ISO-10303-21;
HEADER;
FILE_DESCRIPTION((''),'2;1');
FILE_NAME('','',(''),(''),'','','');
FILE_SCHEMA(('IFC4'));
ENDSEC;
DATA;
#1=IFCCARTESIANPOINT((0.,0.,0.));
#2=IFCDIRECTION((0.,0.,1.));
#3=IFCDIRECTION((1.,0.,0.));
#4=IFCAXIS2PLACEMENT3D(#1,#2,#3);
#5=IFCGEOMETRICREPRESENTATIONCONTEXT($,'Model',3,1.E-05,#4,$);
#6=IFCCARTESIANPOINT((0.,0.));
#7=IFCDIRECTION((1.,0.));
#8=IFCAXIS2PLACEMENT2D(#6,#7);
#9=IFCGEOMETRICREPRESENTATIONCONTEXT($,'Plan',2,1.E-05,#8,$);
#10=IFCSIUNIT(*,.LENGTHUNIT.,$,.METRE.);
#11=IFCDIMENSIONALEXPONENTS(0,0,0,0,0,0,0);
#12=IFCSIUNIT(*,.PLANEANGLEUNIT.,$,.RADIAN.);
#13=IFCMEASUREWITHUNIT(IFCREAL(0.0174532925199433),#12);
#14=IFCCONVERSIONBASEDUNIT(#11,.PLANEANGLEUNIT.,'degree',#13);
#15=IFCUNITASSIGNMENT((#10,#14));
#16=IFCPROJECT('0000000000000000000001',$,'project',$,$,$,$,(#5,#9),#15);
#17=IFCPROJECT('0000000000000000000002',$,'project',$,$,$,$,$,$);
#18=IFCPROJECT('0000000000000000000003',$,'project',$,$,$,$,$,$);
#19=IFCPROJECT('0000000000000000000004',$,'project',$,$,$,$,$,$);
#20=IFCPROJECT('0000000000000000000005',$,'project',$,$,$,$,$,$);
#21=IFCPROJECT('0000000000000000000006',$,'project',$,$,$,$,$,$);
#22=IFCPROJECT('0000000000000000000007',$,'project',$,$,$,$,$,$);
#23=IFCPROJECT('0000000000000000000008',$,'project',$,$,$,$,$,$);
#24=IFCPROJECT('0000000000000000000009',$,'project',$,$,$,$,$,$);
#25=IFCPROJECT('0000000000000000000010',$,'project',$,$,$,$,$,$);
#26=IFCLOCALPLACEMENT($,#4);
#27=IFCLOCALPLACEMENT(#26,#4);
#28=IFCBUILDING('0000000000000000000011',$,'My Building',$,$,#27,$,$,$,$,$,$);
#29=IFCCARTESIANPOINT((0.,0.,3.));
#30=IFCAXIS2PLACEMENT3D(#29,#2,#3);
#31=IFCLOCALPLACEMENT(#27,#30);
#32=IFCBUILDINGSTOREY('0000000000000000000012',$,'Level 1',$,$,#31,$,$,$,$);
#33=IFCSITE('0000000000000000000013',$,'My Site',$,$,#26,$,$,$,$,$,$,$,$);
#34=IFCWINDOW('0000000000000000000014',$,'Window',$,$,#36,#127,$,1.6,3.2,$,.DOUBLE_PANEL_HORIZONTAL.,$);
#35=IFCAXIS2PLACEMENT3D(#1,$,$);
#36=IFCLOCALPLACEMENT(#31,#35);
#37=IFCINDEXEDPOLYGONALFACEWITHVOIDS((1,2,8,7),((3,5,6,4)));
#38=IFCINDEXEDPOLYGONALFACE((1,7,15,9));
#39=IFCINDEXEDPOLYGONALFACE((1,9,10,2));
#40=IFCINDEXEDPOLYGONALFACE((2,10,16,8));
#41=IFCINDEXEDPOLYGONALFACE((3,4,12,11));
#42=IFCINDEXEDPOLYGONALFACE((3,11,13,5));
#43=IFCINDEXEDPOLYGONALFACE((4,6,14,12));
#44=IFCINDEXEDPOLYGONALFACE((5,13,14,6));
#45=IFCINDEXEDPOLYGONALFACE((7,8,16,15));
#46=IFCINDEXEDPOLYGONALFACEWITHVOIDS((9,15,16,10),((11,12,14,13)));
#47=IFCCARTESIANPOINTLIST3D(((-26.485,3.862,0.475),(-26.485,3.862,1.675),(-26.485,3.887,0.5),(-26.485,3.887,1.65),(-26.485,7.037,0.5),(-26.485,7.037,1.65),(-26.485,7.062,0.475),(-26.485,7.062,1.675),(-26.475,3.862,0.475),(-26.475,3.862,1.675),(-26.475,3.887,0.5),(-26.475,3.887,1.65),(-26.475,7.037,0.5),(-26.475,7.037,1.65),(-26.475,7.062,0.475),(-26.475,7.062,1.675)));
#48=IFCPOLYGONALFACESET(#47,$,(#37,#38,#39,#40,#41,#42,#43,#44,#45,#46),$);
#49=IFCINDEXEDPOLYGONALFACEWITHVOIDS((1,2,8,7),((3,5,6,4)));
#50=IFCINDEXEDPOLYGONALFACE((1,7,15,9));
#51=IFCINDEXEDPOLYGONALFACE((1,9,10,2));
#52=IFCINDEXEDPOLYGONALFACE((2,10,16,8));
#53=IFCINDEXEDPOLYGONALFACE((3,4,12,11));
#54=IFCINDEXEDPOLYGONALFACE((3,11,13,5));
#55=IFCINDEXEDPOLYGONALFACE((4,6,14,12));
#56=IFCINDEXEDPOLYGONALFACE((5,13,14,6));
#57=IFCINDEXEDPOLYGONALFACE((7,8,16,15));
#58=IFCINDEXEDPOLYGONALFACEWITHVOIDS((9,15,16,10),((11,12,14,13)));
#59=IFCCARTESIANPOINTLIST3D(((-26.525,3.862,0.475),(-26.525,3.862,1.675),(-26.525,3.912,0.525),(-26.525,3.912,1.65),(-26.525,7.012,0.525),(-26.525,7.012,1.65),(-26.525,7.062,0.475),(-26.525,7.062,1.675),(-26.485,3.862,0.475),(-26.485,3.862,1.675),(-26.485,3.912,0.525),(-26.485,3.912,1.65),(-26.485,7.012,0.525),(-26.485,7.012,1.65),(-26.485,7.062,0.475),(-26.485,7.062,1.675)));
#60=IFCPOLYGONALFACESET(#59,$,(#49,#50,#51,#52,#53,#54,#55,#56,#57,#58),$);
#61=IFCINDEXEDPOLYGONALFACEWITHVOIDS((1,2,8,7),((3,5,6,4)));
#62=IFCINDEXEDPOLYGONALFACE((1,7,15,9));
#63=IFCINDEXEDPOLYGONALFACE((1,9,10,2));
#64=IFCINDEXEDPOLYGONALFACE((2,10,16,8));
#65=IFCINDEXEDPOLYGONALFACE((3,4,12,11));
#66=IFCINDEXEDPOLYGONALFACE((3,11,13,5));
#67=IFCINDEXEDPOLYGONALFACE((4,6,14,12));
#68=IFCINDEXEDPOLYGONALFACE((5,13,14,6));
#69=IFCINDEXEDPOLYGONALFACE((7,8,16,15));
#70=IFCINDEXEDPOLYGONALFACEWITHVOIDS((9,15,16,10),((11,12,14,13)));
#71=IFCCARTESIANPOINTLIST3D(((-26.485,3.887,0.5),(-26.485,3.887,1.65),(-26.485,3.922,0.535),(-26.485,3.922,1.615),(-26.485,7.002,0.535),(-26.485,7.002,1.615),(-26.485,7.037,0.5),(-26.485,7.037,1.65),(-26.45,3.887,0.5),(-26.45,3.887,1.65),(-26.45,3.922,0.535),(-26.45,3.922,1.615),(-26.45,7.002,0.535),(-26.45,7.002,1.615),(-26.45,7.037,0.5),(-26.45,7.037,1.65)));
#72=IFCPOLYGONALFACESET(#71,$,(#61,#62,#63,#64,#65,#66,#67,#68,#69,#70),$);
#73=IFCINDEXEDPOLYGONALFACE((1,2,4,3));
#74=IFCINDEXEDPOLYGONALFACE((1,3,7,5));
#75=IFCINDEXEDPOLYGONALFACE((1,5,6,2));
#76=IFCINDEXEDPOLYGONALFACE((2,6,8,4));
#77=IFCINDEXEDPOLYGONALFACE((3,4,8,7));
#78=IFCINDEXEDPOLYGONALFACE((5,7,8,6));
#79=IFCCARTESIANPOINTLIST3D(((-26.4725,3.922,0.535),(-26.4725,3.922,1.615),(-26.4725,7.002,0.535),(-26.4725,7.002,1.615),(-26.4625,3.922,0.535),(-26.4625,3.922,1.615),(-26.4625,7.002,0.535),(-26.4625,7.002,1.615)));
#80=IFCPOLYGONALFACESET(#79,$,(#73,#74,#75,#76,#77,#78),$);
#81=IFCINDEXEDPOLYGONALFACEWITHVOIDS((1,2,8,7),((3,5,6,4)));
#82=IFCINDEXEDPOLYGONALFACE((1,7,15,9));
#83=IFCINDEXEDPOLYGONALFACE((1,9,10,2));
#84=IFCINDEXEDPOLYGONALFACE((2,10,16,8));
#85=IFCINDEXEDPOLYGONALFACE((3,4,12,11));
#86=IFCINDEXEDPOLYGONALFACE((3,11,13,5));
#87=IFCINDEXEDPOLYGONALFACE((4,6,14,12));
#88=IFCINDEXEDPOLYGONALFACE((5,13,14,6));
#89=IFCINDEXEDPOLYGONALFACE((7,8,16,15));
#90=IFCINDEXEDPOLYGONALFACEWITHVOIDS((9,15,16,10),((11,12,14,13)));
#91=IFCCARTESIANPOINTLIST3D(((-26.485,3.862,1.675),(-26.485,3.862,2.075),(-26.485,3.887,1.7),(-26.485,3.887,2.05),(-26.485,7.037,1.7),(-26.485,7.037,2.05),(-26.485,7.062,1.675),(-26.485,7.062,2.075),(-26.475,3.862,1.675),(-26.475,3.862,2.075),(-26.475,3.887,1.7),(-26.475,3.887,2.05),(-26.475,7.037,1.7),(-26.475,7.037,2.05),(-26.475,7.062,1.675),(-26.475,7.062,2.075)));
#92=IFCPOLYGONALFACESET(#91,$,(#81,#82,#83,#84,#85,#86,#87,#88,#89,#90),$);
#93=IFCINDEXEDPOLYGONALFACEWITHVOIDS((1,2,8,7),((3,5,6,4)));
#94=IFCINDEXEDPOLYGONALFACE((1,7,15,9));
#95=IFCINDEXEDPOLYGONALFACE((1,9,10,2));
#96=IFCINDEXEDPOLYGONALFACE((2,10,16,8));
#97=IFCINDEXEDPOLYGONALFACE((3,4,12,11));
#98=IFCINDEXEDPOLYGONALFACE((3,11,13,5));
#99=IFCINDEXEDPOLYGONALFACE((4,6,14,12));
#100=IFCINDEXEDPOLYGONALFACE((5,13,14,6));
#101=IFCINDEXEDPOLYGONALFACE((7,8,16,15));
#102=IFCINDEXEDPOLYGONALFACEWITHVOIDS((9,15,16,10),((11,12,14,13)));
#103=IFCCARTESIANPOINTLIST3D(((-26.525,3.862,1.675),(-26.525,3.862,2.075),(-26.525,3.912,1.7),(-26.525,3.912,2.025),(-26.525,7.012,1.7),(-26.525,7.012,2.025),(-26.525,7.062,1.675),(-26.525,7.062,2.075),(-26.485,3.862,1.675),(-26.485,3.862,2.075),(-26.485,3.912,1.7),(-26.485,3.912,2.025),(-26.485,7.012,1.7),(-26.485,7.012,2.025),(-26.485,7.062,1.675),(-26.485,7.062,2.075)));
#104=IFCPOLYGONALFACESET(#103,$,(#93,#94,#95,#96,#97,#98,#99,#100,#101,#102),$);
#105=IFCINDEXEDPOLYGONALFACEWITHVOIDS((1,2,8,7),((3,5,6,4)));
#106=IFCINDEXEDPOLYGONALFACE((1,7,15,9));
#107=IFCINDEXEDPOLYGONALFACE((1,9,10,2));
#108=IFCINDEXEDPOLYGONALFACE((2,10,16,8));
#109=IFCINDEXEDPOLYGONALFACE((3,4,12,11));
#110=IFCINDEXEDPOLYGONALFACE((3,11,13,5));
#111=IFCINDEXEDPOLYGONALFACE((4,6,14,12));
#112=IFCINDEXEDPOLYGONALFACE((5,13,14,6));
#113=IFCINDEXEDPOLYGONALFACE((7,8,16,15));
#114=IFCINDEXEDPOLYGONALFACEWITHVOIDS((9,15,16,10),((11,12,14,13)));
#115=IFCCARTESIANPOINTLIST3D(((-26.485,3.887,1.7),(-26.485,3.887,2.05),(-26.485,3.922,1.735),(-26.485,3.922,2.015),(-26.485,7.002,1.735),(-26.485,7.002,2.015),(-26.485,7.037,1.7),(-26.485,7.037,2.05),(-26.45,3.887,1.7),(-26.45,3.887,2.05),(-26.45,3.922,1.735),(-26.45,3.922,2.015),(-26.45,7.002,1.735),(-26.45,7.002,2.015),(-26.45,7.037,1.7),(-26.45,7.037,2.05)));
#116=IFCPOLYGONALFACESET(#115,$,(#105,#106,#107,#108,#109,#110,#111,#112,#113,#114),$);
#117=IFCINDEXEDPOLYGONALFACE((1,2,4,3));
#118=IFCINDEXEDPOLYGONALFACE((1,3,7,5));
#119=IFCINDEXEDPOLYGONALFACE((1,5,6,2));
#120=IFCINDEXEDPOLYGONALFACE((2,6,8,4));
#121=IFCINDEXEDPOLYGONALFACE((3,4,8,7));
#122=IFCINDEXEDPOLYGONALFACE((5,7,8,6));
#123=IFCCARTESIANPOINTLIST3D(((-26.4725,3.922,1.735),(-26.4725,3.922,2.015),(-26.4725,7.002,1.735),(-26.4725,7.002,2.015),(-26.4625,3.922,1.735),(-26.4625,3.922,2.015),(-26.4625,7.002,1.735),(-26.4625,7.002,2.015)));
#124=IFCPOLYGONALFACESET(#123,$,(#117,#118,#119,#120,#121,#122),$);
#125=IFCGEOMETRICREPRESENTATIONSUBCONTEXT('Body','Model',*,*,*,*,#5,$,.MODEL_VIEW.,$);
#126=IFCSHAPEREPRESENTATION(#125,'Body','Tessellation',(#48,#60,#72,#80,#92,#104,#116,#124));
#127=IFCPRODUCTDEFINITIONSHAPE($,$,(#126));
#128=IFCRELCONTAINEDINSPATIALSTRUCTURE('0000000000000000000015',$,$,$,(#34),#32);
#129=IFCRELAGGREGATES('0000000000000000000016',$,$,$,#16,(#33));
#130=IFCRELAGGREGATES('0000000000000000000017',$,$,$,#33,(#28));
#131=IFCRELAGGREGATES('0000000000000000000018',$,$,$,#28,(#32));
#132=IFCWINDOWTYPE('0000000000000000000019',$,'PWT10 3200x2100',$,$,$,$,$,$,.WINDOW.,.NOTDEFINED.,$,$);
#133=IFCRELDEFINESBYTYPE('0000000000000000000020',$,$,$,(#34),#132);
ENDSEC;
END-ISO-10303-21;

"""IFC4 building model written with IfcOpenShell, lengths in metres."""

from ifc_helpers import new_model, entity, si_unit, converted_unit, frame, origin_with_axes, origin_2d_with_axis, place, context, subcontext, project, spatial, line, indexed_curve, outline, extrude, shape, source, transform, mapped, type_object, type_shapes, element, save


model = new_model("IFC4")

# Units and contexts
model_context = context("Model", 3, precision=1e-05, world=origin_with_axes())
plan_context = context("Plan", 2, precision=1e-05, world=origin_2d_with_axis())
body_context_1 = subcontext(model_context, "Body", "Model", "MODEL_VIEW")
body_context_2 = subcontext(plan_context, "Body", "Plan", "PLAN_VIEW")
ifc_project_1 = project(units=[si_unit("LENGTHUNIT", "METRE"), converted_unit("PLANEANGLEUNIT", "degree", entity("IfcReal", 0.0174532925199433), si_unit("PLANEANGLEUNIT", "RADIAN"), dimensions=[0, 0, 0, 0, 0, 0, 0])], contexts=[model_context, plan_context])
ifc_project_2 = project()
ifc_project_3 = project()
ifc_project_4 = project()
ifc_project_5 = project()
ifc_project_6 = project()
ifc_project_7 = project()
ifc_project_8 = project()
ifc_project_9 = project()
ifc_project_10 = project()

# Site, building, storey
site_placement = place(None, origin_with_axes())
site = spatial("IfcSite", under=ifc_project_1, at=site_placement, Name="My Site")
building_placement = place(site_placement, origin_with_axes())
building = spatial("IfcBuilding", under=site, at=building_placement, Name="My Building")
storey_placement = place(building_placement, frame((0.0, 0.0, 3.0), z_axis=(0.0, 0.0, 1.0), x_axis=(1.0, 0.0, 0.0)))
storey = spatial("IfcBuildingStorey", under=building, at=storey_placement, Name="Level 1")

# Window
window_type_1 = type_object("IfcWindowType", Name="PWT10 3200x2100", PartitioningType="NOTDEFINED", PredefinedType="WINDOW")
shared_shape_1 = source(origin_with_axes(), body_context_1, "Body", "SweptSolid", [
    extrude(outline(indexed_curve([(0.0, 0.0), (3.2, 0.0), (3.2, 1.2), (0.0, 1.2)], segments=[line(1, 2, 2, 3, 3, 4, 4, 1)]), holes=[indexed_curve([(0.025, 0.025), (3.175, 0.025), (3.175, 1.175), (0.025, 1.175)], segments=[line(1, 2, 2, 3, 3, 4, 4, 1)])]), frame((0.0, 0.04, 0.0), z_axis=(0.0, -1.0, 0.0), x_axis=(1.0, 0.0, 0.0)), (0.0, 0.0, -1.0), 0.01),
    extrude(outline(indexed_curve([(0.0, 0.0), (3.2, 0.0), (3.2, 1.2), (0.0, 1.2)], segments=[line(1, 2, 2, 3, 3, 4, 4, 1)]), holes=[indexed_curve([(0.05, 0.05), (3.15, 0.05), (3.15, 1.175), (0.05, 1.175)], segments=[line(1, 2, 2, 3, 3, 4, 4, 1)])]), frame((0.0, 0.0, 0.0), z_axis=(0.0, -1.0, 0.0), x_axis=(1.0, 0.0, 0.0)), (0.0, 0.0, -1.0), 0.04),
    extrude(outline(indexed_curve([(0.0, 0.0), (3.15, 0.0), (3.15, 1.15), (0.0, 1.15)], segments=[line(1, 2, 2, 3, 3, 4, 4, 1)]), holes=[indexed_curve([(0.035, 0.035), (3.115, 0.035), (3.115, 1.115), (0.035, 1.115)], segments=[line(1, 2, 2, 3, 3, 4, 4, 1)])]), frame((0.025, 0.04, 0.025), z_axis=(0.0, -1.0, 0.0), x_axis=(1.0, 0.0, 0.0)), (0.0, 0.0, -1.0), 0.035),
    extrude(outline(indexed_curve([(0.035, 0.035), (3.115, 0.035), (3.115, 1.115), (0.035, 1.115)], segments=[line(1, 2, 2, 3, 3, 4, 4, 1)])), frame((0.025, 0.0525, 0.025), z_axis=(0.0, -1.0, 0.0), x_axis=(1.0, 0.0, 0.0)), (0.0, 0.0, -1.0), 0.01),
    extrude(outline(indexed_curve([(0.0, 0.0), (3.2, 0.0), (3.2, 0.4), (0.0, 0.4)], segments=[line(1, 2, 2, 3, 3, 4, 4, 1)]), holes=[indexed_curve([(0.025, 0.025), (3.175, 0.025), (3.175, 0.375), (0.025, 0.375)], segments=[line(1, 2, 2, 3, 3, 4, 4, 1)])]), frame((0.0, 0.04, 1.2), z_axis=(0.0, -1.0, 0.0), x_axis=(1.0, 0.0, 0.0)), (0.0, 0.0, -1.0), 0.01),
    extrude(outline(indexed_curve([(0.0, 0.0), (3.2, 0.0), (3.2, 0.4), (0.0, 0.4)], segments=[line(1, 2, 2, 3, 3, 4, 4, 1)]), holes=[indexed_curve([(0.05, 0.025), (3.15, 0.025), (3.15, 0.35), (0.05, 0.35)], segments=[line(1, 2, 2, 3, 3, 4, 4, 1)])]), frame((0.0, 0.0, 1.2), z_axis=(0.0, -1.0, 0.0), x_axis=(1.0, 0.0, 0.0)), (0.0, 0.0, -1.0), 0.04),
    extrude(outline(indexed_curve([(0.0, 0.0), (3.15, 0.0), (3.15, 0.35), (0.0, 0.35)], segments=[line(1, 2, 2, 3, 3, 4, 4, 1)]), holes=[indexed_curve([(0.035, 0.035), (3.115, 0.035), (3.115, 0.315), (0.035, 0.315)], segments=[line(1, 2, 2, 3, 3, 4, 4, 1)])]), frame((0.025, 0.04, 1.225), z_axis=(0.0, -1.0, 0.0), x_axis=(1.0, 0.0, 0.0)), (0.0, 0.0, -1.0), 0.035),
    extrude(outline(indexed_curve([(0.035, 0.035), (3.115, 0.035), (3.115, 0.315), (0.035, 0.315)], segments=[line(1, 2, 2, 3, 3, 4, 4, 1)])), frame((0.025, 0.0525, 1.225), z_axis=(0.0, -1.0, 0.0), x_axis=(1.0, 0.0, 0.0)), (0.0, 0.0, -1.0), 0.01),
])
shared_shape_2 = source(origin_with_axes(), body_context_2, "Body", "Curve2D", [
    entity("IfcIndexedPolyCurve", entity("IfcCartesianPointList2D", [[0.05, 0.0], [3.15, 0.0]]), [entity("IfcLineIndex", [1, 2])]),
    entity("IfcIndexedPolyCurve", entity("IfcCartesianPointList2D", [[0.0, 0.05], [0.025, 0.05], [0.025, 0.04], [0.05, 0.04], [0.05, 0.0], [0.0, 0.0]]), [entity("IfcLineIndex", [1, 2, 2, 3, 3, 4, 4, 5, 5, 6, 6, 1])]),
    entity("IfcIndexedPolyCurve", entity("IfcCartesianPointList2D", [[3.2, 0.05], [3.175, 0.05], [3.175, 0.04], [3.15, 0.04], [3.15, 0.0], [3.2, 0.0]]), [entity("IfcLineIndex", [1, 2, 2, 3, 3, 4, 4, 5, 5, 6, 6, 1])]),
    entity("IfcIndexedPolyCurve", entity("IfcCartesianPointList2D", [[0.025, 0.04], [0.06, 0.04], [0.06, 0.075], [0.025, 0.075]]), [entity("IfcLineIndex", [1, 2, 2, 3, 3, 4, 4, 1])]),
    entity("IfcIndexedPolyCurve", entity("IfcCartesianPointList2D", [[3.175, 0.04], [3.14, 0.04], [3.14, 0.075], [3.175, 0.075]]), [entity("IfcLineIndex", [1, 2, 2, 3, 3, 4, 4, 1])]),
    entity("IfcIndexedPolyCurve", entity("IfcCartesianPointList2D", [[0.06, 0.04], [3.14, 0.04]]), [entity("IfcLineIndex", [1, 2])]),
    entity("IfcIndexedPolyCurve", entity("IfcCartesianPointList2D", [[0.06, 0.075], [3.14, 0.075]]), [entity("IfcLineIndex", [1, 2])]),
    entity("IfcIndexedPolyCurve", entity("IfcCartesianPointList2D", [[0.06, 0.0575], [3.14, 0.0575]]), [entity("IfcLineIndex", [1, 2])]),
])
type_shapes(window_type_1, [shared_shape_1, shared_shape_2])
window_1_placement = place(storey_placement, frame((-26.525, 7.062, 0.475), z_axis=(0.0, 0.0, 1.0), x_axis=(-0.000001, -1.0, 0.0)))
element("IfcWindow", 1, at=window_1_placement, inside=storey, type_object=window_type_1, Name="Window", OverallHeight=1.6, OverallWidth=3.2, PartitioningType="DOUBLE_PANEL_HORIZONTAL", shapes=[
    shape(body_context_1, "Body", "MappedRepresentation", [mapped(shared_shape_1, transform((0.0, 0.0, 0.0), x_axis=(1.0, 0.0, 0.0), y_axis=(0.0, 1.0, 0.0), z_axis=(0.0, 0.0, 1.0), scale=1.0))]),
    shape(body_context_2, "Body", "MappedRepresentation", [mapped(shared_shape_2, transform((0.0, 0.0, 0.0), x_axis=(1.0, 0.0, 0.0), y_axis=(0.0, 1.0, 0.0), z_axis=(0.0, 0.0, 1.0), scale=1.0))]),
])

save(model, "model.ifc")
